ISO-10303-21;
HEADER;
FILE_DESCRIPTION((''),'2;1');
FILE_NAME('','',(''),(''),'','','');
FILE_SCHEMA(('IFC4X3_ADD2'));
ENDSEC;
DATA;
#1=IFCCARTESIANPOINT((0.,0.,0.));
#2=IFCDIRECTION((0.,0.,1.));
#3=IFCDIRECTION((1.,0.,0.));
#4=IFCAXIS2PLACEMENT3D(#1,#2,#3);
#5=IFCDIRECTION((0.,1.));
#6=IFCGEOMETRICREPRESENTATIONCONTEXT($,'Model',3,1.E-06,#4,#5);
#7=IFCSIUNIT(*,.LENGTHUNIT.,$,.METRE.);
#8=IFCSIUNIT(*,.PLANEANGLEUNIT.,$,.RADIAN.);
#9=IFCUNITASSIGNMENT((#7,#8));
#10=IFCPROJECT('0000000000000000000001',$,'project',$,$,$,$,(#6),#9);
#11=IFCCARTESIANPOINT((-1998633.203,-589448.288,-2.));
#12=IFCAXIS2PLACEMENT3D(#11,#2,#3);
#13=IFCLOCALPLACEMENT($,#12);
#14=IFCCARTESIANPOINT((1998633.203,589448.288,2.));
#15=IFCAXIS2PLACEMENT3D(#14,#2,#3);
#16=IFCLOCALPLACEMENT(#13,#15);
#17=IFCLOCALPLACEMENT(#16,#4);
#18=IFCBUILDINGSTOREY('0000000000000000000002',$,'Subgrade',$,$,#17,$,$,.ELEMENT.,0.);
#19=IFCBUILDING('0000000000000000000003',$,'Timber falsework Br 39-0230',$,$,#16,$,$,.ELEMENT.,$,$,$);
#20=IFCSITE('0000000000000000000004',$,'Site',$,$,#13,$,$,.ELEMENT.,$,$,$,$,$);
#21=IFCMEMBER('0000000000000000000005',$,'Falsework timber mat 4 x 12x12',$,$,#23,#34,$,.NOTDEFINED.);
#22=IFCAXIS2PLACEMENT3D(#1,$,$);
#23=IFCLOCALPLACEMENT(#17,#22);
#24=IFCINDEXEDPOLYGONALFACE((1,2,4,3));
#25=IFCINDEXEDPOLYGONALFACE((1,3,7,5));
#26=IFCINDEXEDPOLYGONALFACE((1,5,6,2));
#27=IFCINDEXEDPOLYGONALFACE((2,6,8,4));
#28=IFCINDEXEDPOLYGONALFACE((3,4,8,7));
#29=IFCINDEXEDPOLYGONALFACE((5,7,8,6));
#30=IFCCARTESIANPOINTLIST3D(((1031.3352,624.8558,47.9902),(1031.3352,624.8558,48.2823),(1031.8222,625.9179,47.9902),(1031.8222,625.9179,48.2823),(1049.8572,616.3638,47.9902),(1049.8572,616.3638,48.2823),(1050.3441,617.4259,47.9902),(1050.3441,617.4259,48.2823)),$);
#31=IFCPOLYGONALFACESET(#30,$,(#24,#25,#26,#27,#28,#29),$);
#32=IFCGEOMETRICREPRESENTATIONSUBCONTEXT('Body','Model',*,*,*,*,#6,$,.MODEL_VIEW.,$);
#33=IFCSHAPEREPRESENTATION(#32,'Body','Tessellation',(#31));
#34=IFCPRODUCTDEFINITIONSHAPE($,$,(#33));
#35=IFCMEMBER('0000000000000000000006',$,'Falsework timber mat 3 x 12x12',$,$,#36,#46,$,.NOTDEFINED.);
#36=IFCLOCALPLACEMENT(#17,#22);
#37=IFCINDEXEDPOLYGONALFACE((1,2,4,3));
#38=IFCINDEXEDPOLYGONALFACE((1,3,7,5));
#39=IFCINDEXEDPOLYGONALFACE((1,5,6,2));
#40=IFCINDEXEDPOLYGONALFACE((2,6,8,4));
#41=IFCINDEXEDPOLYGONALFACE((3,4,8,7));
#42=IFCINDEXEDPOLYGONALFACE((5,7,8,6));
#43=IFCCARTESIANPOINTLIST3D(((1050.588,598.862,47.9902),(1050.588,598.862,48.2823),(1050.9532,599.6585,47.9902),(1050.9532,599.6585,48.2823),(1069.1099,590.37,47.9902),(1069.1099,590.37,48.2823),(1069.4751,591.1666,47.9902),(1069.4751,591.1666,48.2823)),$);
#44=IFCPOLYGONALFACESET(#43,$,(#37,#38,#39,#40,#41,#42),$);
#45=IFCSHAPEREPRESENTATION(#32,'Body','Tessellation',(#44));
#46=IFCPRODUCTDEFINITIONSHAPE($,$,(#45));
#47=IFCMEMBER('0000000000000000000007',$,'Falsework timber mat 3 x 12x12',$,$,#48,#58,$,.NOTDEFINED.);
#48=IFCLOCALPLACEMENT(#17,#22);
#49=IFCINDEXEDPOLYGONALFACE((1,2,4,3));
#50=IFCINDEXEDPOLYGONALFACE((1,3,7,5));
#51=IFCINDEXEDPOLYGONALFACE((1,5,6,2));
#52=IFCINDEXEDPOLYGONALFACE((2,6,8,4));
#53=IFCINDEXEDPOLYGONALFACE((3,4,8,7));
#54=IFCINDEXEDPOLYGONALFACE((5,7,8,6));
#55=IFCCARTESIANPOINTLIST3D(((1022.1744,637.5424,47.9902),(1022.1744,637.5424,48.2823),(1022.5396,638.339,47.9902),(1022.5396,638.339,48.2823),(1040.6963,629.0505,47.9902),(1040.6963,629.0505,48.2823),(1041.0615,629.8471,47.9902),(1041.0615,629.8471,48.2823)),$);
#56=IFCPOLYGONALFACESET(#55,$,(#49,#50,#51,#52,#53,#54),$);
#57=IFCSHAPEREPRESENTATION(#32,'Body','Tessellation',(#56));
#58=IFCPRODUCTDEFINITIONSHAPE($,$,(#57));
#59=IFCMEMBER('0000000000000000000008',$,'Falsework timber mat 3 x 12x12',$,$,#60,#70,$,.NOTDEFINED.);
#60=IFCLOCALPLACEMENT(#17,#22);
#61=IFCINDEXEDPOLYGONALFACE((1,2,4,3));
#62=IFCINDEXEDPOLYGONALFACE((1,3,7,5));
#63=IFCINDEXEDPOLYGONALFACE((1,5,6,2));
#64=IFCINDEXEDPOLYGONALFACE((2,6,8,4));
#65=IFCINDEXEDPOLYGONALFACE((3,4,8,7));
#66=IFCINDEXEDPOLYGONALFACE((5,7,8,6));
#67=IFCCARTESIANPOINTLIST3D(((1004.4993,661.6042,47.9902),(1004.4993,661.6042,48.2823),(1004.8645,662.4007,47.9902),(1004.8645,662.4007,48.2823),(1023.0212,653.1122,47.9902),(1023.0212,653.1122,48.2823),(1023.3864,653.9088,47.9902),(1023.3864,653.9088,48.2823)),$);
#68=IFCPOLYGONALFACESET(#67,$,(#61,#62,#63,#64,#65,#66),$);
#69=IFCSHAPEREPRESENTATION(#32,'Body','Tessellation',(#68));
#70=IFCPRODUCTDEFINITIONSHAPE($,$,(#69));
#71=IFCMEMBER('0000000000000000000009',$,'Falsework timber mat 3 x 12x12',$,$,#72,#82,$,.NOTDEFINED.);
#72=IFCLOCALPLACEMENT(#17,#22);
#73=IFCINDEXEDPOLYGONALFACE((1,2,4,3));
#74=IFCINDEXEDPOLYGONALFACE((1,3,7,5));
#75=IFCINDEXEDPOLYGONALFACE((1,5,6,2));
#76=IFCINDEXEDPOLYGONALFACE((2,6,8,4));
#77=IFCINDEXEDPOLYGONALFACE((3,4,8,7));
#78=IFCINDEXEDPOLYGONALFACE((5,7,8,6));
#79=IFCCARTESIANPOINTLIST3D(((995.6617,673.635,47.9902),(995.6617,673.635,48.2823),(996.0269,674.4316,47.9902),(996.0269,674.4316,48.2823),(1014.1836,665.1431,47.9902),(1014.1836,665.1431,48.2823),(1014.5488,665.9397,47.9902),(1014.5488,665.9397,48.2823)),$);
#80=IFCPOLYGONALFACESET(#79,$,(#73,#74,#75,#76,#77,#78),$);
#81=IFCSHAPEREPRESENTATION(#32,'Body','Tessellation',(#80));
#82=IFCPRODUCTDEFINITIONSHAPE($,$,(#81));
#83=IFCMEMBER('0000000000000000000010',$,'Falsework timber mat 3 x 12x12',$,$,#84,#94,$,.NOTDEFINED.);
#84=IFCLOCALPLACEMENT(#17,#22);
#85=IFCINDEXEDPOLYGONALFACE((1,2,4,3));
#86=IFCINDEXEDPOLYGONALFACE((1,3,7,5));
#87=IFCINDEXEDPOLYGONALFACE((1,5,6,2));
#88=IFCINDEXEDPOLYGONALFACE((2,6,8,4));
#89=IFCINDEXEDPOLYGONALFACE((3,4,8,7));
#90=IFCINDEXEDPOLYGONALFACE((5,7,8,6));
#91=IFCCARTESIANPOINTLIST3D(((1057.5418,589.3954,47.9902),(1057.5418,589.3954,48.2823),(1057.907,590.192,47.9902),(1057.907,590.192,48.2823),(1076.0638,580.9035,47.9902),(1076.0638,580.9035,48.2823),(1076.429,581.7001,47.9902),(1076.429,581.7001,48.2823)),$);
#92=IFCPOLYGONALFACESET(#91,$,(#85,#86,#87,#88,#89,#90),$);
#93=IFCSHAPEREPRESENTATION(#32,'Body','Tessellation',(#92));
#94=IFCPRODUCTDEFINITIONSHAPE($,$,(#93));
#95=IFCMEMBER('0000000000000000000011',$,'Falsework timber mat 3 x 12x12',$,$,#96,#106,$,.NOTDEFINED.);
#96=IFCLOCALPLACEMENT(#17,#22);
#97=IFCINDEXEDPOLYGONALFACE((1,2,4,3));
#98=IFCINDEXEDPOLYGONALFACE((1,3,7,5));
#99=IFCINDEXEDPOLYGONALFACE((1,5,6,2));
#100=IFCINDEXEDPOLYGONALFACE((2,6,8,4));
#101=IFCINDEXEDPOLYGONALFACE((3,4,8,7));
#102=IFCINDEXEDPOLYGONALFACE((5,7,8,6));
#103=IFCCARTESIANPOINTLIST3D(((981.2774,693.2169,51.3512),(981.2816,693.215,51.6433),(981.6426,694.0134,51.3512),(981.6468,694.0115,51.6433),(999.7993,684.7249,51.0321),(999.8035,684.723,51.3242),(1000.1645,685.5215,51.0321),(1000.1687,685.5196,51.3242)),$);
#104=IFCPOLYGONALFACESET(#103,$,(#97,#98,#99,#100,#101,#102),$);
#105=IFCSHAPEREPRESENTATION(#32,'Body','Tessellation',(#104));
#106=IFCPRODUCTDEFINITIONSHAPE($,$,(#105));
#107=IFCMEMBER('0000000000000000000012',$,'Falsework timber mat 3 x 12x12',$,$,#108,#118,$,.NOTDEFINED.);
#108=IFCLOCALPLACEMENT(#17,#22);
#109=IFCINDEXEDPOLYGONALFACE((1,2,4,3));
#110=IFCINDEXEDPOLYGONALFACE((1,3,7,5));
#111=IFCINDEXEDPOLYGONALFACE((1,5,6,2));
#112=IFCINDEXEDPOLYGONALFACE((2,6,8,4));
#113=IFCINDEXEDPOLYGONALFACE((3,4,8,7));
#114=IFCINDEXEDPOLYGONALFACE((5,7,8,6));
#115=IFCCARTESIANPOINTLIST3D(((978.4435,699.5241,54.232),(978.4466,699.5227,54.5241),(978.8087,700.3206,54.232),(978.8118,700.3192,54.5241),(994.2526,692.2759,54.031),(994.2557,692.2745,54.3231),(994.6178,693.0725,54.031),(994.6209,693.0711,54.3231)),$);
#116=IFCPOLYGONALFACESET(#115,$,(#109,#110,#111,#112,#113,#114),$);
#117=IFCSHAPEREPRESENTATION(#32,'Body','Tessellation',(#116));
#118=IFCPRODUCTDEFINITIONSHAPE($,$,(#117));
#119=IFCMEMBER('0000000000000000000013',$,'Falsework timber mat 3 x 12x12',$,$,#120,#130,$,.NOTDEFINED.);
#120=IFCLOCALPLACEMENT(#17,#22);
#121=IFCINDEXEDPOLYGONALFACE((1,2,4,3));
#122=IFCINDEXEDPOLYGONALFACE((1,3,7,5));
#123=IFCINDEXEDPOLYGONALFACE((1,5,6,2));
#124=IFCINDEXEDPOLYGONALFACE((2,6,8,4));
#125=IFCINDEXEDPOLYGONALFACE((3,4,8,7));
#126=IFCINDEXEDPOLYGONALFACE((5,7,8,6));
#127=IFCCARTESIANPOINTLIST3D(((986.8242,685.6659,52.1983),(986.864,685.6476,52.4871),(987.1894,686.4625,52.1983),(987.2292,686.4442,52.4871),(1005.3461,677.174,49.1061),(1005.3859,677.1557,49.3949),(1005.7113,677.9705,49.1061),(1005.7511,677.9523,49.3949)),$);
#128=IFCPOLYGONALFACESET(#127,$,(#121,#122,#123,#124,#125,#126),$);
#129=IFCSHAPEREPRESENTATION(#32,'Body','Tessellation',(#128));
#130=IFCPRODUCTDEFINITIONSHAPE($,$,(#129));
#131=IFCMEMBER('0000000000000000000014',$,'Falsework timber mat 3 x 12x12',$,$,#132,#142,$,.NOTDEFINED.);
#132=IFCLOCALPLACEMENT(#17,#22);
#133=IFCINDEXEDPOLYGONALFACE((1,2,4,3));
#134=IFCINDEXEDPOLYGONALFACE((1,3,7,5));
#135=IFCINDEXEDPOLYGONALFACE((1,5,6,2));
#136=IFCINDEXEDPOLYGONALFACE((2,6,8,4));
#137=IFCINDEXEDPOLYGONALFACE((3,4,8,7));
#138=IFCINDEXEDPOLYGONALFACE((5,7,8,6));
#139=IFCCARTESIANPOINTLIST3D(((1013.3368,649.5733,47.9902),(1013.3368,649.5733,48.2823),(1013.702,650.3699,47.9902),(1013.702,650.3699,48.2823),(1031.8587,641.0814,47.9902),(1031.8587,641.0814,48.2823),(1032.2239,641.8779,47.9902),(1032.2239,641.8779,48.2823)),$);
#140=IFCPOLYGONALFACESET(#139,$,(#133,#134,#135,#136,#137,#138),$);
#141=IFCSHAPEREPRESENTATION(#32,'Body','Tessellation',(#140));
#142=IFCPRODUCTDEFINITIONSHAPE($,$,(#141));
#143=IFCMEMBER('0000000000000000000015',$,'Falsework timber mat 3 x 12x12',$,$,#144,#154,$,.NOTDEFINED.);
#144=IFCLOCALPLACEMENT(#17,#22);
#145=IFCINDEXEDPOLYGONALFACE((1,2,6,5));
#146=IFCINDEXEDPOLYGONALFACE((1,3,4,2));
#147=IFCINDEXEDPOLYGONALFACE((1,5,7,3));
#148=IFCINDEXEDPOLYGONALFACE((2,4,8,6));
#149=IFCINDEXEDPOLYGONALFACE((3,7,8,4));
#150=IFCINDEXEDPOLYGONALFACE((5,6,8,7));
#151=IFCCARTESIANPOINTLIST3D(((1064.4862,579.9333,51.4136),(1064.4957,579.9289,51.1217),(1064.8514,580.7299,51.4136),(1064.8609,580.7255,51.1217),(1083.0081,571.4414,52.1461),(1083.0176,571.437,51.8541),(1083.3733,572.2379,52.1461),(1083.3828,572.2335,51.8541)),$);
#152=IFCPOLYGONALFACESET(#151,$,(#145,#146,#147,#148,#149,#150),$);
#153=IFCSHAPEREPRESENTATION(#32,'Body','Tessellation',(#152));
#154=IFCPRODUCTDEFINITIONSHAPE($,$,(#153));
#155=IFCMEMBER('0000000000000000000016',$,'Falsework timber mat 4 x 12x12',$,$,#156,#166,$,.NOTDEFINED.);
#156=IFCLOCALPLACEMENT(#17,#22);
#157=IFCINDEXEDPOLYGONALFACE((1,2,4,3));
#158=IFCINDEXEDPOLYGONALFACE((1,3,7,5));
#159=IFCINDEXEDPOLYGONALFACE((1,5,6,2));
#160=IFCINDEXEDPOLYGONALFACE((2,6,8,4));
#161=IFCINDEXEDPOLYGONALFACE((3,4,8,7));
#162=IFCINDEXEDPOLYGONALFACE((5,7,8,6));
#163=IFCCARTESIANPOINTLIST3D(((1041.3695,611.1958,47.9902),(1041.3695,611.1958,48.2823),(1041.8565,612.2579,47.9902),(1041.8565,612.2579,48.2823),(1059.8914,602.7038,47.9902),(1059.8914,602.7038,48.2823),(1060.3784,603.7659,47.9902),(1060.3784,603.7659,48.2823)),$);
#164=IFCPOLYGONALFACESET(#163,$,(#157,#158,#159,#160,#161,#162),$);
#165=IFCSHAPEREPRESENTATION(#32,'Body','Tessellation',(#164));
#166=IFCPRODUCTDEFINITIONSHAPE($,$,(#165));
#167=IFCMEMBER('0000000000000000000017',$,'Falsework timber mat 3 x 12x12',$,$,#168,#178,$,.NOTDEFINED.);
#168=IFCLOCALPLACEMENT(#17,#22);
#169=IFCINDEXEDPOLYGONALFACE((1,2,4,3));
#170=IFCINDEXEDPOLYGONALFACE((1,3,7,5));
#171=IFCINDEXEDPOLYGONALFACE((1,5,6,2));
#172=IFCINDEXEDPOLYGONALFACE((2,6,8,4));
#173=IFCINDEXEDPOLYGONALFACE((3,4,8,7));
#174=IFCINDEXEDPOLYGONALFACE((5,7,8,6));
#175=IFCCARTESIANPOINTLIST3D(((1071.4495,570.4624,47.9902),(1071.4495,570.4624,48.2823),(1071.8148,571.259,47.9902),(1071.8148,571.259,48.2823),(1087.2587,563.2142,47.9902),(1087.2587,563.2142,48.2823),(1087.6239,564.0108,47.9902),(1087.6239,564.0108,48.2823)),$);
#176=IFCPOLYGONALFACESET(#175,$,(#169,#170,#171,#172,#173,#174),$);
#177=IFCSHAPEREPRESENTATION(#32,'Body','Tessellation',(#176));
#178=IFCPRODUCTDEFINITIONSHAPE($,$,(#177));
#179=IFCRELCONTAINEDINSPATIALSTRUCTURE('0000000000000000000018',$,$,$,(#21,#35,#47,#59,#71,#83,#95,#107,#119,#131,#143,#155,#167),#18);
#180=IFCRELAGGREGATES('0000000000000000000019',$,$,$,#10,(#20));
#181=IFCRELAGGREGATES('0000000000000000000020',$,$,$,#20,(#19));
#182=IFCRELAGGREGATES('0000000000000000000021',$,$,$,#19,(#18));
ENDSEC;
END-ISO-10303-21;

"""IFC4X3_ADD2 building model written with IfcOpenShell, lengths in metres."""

from ifc_helpers import new_model, si_unit, direction, frame, frame_2d, origin, origin_with_axes, place, context, subcontext, project, spatial, rectangle, extrude, element, save


model = new_model("IFC4X3_ADD2")

# Units and contexts
model_context = context("Model", 3, precision=1e-06, world=origin_with_axes(), true_north=direction((0.0, 1.0)))
body_context = subcontext(model_context, "Body", "Model", "MODEL_VIEW")
ifc_project = project(units=[si_unit("LENGTHUNIT", "METRE"), si_unit("PLANEANGLEUNIT", "RADIAN")], contexts=[model_context])

# Site, building, storey
site_placement = place(None, frame((-1998633.203, -589448.288, -2.0), z_axis=(0.0, 0.0, 1.0), x_axis=(1.0, 0.0, 0.0)))
site = spatial("IfcSite", under=ifc_project, at=site_placement, Name="Site", CompositionType="ELEMENT")
building_placement = place(site_placement, frame((1998633.203, 589448.288, 2.0), z_axis=(0.0, 0.0, 1.0), x_axis=(1.0, 0.0, 0.0)))
building = spatial("IfcBuilding", under=site, at=building_placement, Name="Timber falsework Br 39-0230", CompositionType="ELEMENT")
storey_placement = place(building_placement, origin_with_axes())
storey = spatial("IfcBuildingStorey", under=building, at=storey_placement, Name="Subgrade", CompositionType="ELEMENT", Elevation=0.0)

# Members
member_1_placement = place(storey_placement, frame((1031.5787, 625.3868, 47.9902), z_axis=(0.909014, -0.416765, 0.0), x_axis=(0.416765, 0.909014, 0.0)))
element("IfcMember", 1, at=member_1_placement, inside=storey, Name="Falsework timber mat 4 x 12x12", PredefinedType="NOTDEFINED", context=body_context, shape_type="SweptSolid", body=[
    extrude(rectangle(XDim=1.1684, YDim=0.2921, at=frame_2d((0.0, 0.146))), origin(), (0.0, 0.0, 1.0), 20.3758),
])
member_2_placement = place(storey_placement, frame((1050.7706, 599.2602, 47.9902), z_axis=(0.909014, -0.416765, 0.0), x_axis=(0.416765, 0.909014, 0.0)))
element("IfcMember", 2, at=member_2_placement, inside=storey, Name="Falsework timber mat 3 x 12x12", PredefinedType="NOTDEFINED", context=body_context, shape_type="SweptSolid", body=[
    extrude(rectangle(XDim=0.8763, YDim=0.2921, at=frame_2d((0.0, 0.146))), origin(), (0.0, 0.0, 1.0), 20.3758),
])
member_3_placement = place(storey_placement, frame((1022.357, 637.9407, 47.9902), z_axis=(0.909014, -0.416765, 0.0), x_axis=(0.416765, 0.909014, 0.0)))
element("IfcMember", 3, at=member_3_placement, inside=storey, Name="Falsework timber mat 3 x 12x12", PredefinedType="NOTDEFINED", context=body_context, shape_type="SweptSolid", body=[
    extrude(rectangle(XDim=0.8763, YDim=0.2921, at=frame_2d((0.0, 0.146))), origin(), (0.0, 0.0, 1.0), 20.3758),
])
member_4_placement = place(storey_placement, frame((1004.6819, 662.0025, 47.9902), z_axis=(0.909014, -0.416765, 0.0), x_axis=(0.416765, 0.909014, 0.0)))
element("IfcMember", 4, at=member_4_placement, inside=storey, Name="Falsework timber mat 3 x 12x12", PredefinedType="NOTDEFINED", context=body_context, shape_type="SweptSolid", body=[
    extrude(rectangle(XDim=0.8763, YDim=0.2921, at=frame_2d((0.0, 0.146))), origin(), (0.0, 0.0, 1.0), 20.3758),
])
for number, where, z_axis, x_axis, name in (
    (5, (995.8443, 674.0333, 47.9902), (0.909014, -0.416765, 0.0), (0.416765, 0.909014, 0.0), "Falsework timber mat 3 x 12x12"),
    (6, (1057.7244, 589.7937, 47.9902), (0.909014, -0.416765, 0.0), (0.416765, 0.909014, 0.0), "Falsework timber mat 3 x 12x12"),
):
    element("IfcMember", number, at=place(storey_placement, frame(where, z_axis=z_axis, x_axis=x_axis)), inside=storey, Name=name, PredefinedType="NOTDEFINED", context=body_context, shape_type="SweptSolid", body=[
        extrude(rectangle(XDim=0.8763, YDim=0.2921, at=frame_2d((0.0, 0.146))), origin(), (0.0, 0.0, 1.0), 20.3758),
    ])
member_5_placement = place(storey_placement, frame((981.46, 693.6152, 51.3512), z_axis=(0.908903, -0.416714, -0.015657), x_axis=(0.416765, 0.909014, 0.0)))
element("IfcMember", 7, at=member_5_placement, inside=storey, Name="Falsework timber mat 3 x 12x12", PredefinedType="NOTDEFINED", context=body_context, shape_type="SweptSolid", body=[
    extrude(rectangle(XDim=0.8763, YDim=0.2921, at=frame_2d((0.0, 0.146))), origin(), (0.0, 0.0, 1.0), 20.3783),
])
member_6_placement = place(storey_placement, frame((978.6261, 699.9224, 54.232), z_axis=(0.908953, -0.416737, -0.011557), x_axis=(0.416765, 0.909014, 0.0)))
element("IfcMember", 8, at=member_6_placement, inside=storey, Name="Falsework timber mat 3 x 12x12", PredefinedType="NOTDEFINED", context=body_context, shape_type="SweptSolid", body=[
    extrude(rectangle(XDim=0.8763, YDim=0.2921, at=frame_2d((0.0, 0.146))), origin(), (0.0, 0.0, 1.0), 17.3927),
])
member_7_placement = place(storey_placement, frame((987.0068, 686.0642, 52.1983), z_axis=(0.898724, -0.412047, -0.150039), x_axis=(0.416765, 0.909014, 0.0)))
element("IfcMember", 9, at=member_7_placement, inside=storey, Name="Falsework timber mat 3 x 12x12", PredefinedType="NOTDEFINED", context=body_context, shape_type="SweptSolid", body=[
    extrude(rectangle(XDim=0.8763, YDim=0.2921, at=frame_2d((0.0, 0.146))), origin(), (0.0, 0.0, 1.0), 20.6091),
])
member_8_placement = place(storey_placement, frame((1013.5194, 649.9716, 47.9902), z_axis=(0.909014, -0.416765, 0.0), x_axis=(0.416765, 0.909014, 0.0)))
element("IfcMember", 10, at=member_8_placement, inside=storey, Name="Falsework timber mat 3 x 12x12", PredefinedType="NOTDEFINED", context=body_context, shape_type="SweptSolid", body=[
    extrude(rectangle(XDim=0.8763, YDim=0.2921, at=frame_2d((0.0, 0.146))), origin(), (0.0, 0.0, 1.0), 20.3758),
])
member_9_placement = place(storey_placement, frame((1064.6783, 580.3272, 51.1217), z_axis=(0.908427, -0.416496, 0.035924), x_axis=(0.416765, 0.909014, 0.0)))
element("IfcMember", 11, at=member_9_placement, inside=storey, Name="Falsework timber mat 3 x 12x12", PredefinedType="NOTDEFINED", context=body_context, shape_type="SweptSolid", body=[
    extrude(rectangle(XDim=0.8763, YDim=0.2921, at=frame_2d((0.0, 0.146))), origin(), (0.0, 0.0, 1.0), 20.389),
])
member_10_placement = place(storey_placement, frame((1041.613, 611.7268, 47.9902), z_axis=(0.909014, -0.416765, 0.0), x_axis=(0.416765, 0.909014, 0.0)))
element("IfcMember", 12, at=member_10_placement, inside=storey, Name="Falsework timber mat 4 x 12x12", PredefinedType="NOTDEFINED", context=body_context, shape_type="SweptSolid", body=[
    extrude(rectangle(XDim=1.1684, YDim=0.2921, at=frame_2d((0.0, 0.146))), origin(), (0.0, 0.0, 1.0), 20.3758),
])
member_11_placement = place(storey_placement, frame((1071.6321, 570.8607, 47.9902), z_axis=(0.909014, -0.416765, 0.0), x_axis=(0.416765, 0.909014, 0.0)))
element("IfcMember", 13, at=member_11_placement, inside=storey, Name="Falsework timber mat 3 x 12x12", PredefinedType="NOTDEFINED", context=body_context, shape_type="SweptSolid", body=[
    extrude(rectangle(XDim=0.8763, YDim=0.2921, at=frame_2d((0.0, 0.146))), origin(), (0.0, 0.0, 1.0), 17.3915),
])

save(model, "model.ifc")
